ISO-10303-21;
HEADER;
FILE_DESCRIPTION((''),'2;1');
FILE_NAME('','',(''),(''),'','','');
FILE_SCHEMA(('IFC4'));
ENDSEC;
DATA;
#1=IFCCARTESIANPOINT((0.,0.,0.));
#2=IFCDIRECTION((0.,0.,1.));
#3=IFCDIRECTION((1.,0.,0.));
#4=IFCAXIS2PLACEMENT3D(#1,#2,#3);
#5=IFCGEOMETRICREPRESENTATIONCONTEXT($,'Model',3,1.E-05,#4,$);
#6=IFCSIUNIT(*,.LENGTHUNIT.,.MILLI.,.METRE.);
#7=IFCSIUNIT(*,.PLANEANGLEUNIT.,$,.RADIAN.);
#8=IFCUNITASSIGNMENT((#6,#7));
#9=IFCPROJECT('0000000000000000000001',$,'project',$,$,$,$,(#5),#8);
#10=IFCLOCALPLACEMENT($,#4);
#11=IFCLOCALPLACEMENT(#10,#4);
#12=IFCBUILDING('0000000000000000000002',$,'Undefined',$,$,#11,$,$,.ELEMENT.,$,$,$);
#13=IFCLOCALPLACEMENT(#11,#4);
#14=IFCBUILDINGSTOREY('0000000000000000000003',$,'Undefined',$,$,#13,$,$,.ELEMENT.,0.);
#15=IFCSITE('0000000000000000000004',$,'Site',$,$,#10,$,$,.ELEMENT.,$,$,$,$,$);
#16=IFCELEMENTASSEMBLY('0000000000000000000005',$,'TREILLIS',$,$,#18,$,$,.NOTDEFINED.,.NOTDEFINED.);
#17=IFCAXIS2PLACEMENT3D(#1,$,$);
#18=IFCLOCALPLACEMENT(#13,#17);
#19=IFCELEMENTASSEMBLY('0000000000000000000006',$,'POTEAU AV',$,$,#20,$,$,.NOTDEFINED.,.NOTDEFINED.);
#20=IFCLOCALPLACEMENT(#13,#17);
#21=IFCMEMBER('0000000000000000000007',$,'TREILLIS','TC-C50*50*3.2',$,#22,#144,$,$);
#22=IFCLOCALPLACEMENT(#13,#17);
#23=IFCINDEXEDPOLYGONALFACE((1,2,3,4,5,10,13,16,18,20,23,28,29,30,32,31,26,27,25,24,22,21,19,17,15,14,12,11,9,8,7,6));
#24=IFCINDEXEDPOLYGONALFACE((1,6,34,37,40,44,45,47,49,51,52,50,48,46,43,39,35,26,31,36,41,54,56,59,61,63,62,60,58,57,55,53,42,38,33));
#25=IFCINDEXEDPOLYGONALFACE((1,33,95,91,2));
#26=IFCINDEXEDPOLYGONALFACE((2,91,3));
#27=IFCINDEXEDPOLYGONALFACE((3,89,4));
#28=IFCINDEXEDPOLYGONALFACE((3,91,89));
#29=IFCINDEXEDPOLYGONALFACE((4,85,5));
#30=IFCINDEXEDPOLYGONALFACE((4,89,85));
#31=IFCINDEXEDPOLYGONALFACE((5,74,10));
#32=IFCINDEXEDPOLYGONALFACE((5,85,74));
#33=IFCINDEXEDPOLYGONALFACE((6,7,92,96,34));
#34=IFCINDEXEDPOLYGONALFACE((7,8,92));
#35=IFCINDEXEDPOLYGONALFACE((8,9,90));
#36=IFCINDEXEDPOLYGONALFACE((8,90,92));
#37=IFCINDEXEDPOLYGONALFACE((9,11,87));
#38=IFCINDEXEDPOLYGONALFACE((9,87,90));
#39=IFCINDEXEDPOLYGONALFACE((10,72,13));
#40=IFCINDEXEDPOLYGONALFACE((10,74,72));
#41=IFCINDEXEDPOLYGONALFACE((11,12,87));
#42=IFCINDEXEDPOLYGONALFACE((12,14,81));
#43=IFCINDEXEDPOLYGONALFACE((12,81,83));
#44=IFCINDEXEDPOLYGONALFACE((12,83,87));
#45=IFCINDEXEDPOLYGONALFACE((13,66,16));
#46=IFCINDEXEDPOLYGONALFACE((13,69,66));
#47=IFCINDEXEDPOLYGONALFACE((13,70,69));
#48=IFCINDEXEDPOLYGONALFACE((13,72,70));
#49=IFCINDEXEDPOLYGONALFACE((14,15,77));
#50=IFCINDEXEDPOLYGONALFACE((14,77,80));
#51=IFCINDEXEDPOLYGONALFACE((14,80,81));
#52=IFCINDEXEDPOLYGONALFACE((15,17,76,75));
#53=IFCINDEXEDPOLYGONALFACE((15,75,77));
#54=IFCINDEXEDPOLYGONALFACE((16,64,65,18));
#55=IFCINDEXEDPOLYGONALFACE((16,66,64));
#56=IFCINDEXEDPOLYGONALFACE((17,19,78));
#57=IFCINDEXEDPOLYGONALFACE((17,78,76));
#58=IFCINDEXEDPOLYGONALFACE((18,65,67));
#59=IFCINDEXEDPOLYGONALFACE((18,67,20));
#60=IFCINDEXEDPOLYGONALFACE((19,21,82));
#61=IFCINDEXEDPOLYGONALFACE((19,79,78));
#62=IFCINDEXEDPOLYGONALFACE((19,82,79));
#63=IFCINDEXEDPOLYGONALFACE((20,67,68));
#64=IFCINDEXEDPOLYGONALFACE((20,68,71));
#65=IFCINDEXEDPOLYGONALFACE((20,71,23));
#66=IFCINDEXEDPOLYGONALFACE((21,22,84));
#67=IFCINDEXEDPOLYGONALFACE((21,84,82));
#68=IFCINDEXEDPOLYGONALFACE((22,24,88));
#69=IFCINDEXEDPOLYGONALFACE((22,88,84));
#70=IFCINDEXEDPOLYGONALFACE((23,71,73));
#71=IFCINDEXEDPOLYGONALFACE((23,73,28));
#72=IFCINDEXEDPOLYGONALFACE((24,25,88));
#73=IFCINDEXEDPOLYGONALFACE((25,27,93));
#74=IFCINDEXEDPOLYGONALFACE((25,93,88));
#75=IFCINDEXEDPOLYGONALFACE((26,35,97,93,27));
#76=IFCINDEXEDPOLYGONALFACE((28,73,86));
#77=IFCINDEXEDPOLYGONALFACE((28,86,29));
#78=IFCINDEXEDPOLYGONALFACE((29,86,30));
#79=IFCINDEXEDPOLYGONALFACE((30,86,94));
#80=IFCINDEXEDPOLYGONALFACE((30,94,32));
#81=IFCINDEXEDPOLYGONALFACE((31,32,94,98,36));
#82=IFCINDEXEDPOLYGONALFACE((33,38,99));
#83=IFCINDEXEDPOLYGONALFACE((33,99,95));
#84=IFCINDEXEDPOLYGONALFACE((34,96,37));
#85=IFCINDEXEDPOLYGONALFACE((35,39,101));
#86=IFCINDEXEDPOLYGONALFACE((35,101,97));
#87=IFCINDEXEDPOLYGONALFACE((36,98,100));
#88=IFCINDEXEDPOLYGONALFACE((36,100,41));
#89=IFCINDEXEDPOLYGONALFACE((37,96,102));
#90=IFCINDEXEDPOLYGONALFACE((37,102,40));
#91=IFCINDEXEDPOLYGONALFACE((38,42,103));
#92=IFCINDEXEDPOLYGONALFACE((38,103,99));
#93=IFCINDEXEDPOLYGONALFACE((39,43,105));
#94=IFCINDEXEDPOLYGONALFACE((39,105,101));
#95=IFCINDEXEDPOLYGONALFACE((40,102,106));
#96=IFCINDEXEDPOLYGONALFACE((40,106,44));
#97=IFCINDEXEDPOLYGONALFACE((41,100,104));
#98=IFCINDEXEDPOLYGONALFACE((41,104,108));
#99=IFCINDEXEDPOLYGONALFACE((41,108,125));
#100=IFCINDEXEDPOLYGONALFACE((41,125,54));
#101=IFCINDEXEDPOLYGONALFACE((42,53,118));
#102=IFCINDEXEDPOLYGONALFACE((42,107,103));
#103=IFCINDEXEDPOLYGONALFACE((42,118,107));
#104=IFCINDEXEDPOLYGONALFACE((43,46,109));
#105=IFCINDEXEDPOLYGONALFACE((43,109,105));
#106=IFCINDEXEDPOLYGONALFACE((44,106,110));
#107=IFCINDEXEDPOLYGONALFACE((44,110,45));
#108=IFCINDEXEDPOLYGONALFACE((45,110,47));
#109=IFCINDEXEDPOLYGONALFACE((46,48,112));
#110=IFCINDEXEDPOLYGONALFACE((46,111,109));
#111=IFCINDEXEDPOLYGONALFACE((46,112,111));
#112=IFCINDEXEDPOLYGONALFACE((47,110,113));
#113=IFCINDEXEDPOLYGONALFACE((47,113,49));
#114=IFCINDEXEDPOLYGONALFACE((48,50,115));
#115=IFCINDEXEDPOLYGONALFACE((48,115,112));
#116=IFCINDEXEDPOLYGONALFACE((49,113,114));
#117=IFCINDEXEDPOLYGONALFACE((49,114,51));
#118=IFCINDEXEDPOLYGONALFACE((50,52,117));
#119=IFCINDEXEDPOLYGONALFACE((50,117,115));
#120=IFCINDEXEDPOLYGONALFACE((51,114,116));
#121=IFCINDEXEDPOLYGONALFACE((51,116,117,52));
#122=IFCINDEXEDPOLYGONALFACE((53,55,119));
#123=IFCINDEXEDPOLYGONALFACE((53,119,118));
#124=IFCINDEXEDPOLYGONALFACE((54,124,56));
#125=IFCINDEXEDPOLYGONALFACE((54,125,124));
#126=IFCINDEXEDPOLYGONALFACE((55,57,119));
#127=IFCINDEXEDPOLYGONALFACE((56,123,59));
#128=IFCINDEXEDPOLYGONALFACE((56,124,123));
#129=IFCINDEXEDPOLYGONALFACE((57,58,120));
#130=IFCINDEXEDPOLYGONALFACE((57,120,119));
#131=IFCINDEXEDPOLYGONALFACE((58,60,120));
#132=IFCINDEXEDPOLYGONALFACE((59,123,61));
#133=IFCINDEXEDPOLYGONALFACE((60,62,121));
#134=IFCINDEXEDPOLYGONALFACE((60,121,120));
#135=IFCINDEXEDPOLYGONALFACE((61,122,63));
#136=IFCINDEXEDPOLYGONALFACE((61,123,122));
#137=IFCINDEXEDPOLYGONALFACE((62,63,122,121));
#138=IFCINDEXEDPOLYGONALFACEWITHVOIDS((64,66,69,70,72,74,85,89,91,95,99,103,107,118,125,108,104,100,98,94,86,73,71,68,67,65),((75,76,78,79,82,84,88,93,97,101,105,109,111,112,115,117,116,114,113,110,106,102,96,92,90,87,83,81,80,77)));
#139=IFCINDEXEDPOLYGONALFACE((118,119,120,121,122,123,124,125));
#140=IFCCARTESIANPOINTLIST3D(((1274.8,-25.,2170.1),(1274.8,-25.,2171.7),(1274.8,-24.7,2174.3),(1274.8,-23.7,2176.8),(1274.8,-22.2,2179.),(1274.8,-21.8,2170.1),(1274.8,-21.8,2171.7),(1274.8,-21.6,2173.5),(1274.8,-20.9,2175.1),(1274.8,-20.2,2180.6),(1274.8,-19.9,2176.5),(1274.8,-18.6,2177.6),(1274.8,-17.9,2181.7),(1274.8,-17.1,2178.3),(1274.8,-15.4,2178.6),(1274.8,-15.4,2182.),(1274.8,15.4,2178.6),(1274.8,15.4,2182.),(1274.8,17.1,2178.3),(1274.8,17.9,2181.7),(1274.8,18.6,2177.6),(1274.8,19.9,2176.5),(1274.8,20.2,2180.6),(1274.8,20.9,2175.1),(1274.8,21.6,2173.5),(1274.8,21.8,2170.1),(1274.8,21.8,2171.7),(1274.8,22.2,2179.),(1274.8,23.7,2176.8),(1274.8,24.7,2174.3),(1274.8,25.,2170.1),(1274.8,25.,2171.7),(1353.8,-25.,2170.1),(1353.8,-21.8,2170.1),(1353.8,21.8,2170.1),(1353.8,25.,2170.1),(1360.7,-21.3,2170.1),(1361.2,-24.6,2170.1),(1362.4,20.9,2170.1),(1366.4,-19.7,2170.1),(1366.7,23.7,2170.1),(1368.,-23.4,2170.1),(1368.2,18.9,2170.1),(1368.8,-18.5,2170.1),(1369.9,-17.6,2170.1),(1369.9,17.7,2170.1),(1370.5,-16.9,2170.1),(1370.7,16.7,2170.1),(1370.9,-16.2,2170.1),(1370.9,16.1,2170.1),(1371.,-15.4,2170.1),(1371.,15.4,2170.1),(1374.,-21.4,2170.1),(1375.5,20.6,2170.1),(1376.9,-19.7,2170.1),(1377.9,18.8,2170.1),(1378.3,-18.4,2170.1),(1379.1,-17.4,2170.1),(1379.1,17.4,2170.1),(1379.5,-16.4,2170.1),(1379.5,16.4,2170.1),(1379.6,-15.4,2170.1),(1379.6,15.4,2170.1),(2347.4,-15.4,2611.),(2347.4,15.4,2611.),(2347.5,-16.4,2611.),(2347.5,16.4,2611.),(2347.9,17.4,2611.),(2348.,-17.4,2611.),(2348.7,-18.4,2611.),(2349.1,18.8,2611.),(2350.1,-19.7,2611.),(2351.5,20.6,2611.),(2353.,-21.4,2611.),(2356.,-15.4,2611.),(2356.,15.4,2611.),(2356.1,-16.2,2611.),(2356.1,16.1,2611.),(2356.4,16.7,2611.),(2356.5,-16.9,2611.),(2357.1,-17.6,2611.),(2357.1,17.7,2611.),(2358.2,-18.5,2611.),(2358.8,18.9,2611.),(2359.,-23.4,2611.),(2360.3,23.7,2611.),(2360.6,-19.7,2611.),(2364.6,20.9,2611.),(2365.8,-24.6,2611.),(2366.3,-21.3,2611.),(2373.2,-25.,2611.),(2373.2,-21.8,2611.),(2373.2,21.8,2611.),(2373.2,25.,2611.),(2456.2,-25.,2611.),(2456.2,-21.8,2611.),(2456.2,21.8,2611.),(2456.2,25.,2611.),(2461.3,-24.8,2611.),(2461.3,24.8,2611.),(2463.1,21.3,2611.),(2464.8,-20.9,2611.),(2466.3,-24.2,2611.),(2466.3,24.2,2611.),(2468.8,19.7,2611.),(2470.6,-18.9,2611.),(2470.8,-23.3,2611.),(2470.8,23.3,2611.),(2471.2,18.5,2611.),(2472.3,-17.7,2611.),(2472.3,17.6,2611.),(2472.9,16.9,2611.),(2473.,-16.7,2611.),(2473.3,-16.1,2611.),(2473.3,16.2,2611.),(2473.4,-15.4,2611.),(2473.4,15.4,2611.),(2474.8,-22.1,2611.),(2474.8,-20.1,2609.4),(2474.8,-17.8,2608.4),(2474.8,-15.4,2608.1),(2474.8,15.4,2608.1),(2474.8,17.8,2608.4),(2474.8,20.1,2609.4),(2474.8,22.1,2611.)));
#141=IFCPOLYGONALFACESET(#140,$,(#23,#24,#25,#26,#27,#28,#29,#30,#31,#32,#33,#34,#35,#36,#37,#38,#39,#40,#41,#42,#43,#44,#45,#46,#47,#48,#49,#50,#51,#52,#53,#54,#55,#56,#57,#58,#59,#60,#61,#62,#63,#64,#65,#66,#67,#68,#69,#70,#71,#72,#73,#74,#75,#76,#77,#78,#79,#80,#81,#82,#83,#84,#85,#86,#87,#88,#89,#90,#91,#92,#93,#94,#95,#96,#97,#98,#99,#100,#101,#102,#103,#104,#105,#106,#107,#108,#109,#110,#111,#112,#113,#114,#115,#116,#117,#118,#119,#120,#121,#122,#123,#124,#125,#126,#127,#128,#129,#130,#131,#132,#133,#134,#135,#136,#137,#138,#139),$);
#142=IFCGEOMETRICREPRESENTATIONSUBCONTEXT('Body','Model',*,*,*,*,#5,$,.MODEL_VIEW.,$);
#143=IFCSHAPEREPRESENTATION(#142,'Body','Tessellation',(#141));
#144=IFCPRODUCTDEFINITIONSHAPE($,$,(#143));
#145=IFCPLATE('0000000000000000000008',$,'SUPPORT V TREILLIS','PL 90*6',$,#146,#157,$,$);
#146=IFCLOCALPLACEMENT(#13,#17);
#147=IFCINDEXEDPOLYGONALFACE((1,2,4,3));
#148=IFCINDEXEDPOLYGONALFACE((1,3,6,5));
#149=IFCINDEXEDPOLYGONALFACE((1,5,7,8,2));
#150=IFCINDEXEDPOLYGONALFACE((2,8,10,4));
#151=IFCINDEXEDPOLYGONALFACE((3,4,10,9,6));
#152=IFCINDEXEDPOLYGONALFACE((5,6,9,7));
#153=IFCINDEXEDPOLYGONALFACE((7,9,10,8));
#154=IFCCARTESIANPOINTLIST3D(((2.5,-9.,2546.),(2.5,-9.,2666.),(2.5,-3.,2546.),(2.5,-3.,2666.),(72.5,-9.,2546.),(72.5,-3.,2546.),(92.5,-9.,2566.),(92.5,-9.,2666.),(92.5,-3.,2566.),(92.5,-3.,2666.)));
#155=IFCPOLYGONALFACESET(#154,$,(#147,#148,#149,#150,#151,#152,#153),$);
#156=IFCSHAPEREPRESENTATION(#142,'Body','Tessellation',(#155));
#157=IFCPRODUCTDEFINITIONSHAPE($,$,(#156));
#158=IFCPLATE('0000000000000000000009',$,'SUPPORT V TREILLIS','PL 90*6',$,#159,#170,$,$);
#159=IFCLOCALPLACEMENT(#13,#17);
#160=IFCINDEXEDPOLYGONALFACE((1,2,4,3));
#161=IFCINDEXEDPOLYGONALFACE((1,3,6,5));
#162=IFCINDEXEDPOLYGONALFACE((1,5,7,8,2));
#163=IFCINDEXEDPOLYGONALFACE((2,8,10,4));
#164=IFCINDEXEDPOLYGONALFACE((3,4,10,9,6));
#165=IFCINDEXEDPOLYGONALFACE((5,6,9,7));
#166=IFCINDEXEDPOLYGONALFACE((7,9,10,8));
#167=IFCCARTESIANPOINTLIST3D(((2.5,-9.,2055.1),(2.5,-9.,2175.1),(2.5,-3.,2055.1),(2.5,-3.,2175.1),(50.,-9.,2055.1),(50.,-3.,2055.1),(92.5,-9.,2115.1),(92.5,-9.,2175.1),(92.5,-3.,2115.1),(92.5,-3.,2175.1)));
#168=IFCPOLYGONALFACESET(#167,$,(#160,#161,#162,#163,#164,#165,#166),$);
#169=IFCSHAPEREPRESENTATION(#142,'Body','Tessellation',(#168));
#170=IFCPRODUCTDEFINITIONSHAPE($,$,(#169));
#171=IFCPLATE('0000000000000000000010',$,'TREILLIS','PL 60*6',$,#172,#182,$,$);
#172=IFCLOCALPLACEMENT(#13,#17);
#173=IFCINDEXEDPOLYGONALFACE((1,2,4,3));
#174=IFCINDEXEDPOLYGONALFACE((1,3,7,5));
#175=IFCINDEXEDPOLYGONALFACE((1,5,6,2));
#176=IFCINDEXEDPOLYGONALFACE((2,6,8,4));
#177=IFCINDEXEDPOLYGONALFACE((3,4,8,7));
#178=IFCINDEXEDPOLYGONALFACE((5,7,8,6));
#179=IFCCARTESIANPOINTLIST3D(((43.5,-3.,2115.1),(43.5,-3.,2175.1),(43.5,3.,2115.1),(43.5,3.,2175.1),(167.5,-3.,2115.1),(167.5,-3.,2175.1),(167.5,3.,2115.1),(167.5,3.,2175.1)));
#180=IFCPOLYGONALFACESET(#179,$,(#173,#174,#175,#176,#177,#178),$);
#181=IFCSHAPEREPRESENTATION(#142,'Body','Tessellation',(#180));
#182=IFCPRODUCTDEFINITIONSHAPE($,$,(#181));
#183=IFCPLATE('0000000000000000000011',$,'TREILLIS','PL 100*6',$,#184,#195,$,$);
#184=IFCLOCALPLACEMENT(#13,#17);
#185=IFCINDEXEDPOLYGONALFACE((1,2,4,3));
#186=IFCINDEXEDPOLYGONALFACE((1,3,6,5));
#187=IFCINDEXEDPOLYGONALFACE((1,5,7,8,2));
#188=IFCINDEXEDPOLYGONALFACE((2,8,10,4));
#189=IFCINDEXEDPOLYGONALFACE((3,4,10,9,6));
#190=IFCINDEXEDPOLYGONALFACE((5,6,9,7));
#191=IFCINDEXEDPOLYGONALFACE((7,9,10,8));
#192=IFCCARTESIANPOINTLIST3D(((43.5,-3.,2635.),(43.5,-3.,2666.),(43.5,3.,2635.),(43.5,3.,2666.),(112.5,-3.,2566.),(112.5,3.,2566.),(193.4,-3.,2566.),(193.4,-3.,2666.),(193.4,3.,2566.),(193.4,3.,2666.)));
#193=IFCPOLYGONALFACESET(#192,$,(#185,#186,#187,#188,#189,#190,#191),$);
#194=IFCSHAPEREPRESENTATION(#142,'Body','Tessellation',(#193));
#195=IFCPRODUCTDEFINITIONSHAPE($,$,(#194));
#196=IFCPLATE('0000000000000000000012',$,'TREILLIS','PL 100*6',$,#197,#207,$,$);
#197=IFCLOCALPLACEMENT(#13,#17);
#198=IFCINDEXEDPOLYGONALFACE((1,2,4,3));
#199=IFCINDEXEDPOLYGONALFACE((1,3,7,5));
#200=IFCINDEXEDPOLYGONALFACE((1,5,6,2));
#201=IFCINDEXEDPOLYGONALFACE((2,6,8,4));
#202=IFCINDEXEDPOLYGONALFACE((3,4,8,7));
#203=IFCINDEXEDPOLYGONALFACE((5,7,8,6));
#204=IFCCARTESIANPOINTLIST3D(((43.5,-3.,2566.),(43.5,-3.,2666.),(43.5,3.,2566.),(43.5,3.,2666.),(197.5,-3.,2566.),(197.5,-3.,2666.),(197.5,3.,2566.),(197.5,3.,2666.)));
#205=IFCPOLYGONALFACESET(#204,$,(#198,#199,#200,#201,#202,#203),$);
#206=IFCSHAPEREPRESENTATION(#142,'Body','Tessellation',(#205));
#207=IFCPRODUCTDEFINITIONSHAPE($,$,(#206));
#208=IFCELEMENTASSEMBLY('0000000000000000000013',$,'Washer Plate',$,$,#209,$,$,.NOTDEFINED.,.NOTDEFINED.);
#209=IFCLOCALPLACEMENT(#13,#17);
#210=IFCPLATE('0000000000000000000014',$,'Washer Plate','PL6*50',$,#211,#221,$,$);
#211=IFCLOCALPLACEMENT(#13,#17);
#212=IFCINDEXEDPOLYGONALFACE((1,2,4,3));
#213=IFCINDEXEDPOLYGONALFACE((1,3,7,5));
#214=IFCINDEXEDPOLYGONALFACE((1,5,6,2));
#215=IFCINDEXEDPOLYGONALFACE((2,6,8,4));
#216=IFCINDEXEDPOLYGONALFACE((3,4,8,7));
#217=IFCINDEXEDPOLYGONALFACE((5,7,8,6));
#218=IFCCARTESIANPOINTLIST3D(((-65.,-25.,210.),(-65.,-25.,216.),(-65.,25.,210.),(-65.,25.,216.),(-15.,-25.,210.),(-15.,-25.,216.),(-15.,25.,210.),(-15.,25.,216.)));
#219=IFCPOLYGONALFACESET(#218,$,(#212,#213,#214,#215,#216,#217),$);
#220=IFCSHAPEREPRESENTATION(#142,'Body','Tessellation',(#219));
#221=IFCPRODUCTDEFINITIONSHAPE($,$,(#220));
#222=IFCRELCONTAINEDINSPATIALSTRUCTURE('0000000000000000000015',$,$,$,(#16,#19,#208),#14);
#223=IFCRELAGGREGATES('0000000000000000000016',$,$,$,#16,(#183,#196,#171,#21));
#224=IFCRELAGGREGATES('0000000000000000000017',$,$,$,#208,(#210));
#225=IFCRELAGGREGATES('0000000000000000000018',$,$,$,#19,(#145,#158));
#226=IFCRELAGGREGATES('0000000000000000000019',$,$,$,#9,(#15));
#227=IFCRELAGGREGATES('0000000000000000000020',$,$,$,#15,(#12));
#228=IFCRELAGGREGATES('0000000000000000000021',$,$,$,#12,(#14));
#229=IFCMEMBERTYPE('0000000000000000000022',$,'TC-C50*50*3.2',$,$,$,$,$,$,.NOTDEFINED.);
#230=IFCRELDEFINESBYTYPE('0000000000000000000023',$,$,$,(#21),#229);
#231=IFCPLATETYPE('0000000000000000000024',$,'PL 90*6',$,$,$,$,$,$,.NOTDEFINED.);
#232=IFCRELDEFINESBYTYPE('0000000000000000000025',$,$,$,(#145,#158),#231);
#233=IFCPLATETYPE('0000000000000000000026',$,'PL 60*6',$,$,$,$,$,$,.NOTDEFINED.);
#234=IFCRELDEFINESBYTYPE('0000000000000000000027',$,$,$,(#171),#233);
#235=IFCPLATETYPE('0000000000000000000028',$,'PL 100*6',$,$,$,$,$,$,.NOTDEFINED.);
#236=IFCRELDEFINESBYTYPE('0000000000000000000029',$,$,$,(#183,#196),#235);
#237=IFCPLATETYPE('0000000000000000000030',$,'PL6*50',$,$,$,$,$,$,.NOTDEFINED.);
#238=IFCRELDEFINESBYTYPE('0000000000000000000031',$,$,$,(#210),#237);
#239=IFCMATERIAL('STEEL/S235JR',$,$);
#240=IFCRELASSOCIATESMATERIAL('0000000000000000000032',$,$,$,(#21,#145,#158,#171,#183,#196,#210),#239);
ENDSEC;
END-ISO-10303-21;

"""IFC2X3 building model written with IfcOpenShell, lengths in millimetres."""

from ifc_helpers import new_model, si_unit, frame, origin_with_axes, origin_2d_with_axis, place, context, subcontext, project, spatial, polyline, hollow_rectangle, outline, extrude, clip, halfspace, material, type_object, element, aggregate, save


model = new_model("IFC2X3")

# Units and contexts
model_context = context("Model", 3, precision=1e-05, world=origin_with_axes())
body_context = subcontext(model_context, "Body", "Model", "MODEL_VIEW")
ifc_project = project(units=[si_unit("LENGTHUNIT", "METRE", prefix="MILLI"), si_unit("PLANEANGLEUNIT", "RADIAN")], contexts=[model_context])

# Site, building, storey
site_placement = place(None, origin_with_axes())
site = spatial("IfcSite", under=ifc_project, at=site_placement, Name="Site", CompositionType="ELEMENT")
building_placement = place(site_placement, origin_with_axes())
building = spatial("IfcBuilding", under=site, at=building_placement, Name="Undefined", CompositionType="ELEMENT")
storey_placement = place(building_placement, origin_with_axes())
storey = spatial("IfcBuildingStorey", under=building, at=storey_placement, Name="Undefined", CompositionType="ELEMENT", Elevation=0.0)

# Shared definitions
ifc_material_1 = material(Name="STEEL/S235JR")

# Element assembly
assembly_1_placement = place(storey_placement, origin_with_axes())
assembly_1 = element("IfcElementAssembly", 1, at=assembly_1_placement, inside=storey, Name="TREILLIS", AssemblyPlace="NOTDEFINED", PredefinedType="NOTDEFINED")

# Element assembly
assembly_2_placement = place(storey_placement, origin_with_axes())
assembly_2 = element("IfcElementAssembly", 2, at=assembly_2_placement, inside=storey, Name="POTEAU AV", AssemblyPlace="NOTDEFINED", PredefinedType="NOTDEFINED")

# Member
member_type = type_object("IfcMemberType", Name="TC-C50*50*3.2", PredefinedType="NOTDEFINED")
member_1_placement = place(assembly_1_placement, frame((1249.9, 0.0, 2145.1), z_axis=(-0.371369, 0.0, 0.928485), x_axis=(0.928485, 0.0, 0.371369)))
member_1 = element("IfcMember", 3, at=member_1_placement, type_object=member_type, material=ifc_material_1, Name="TREILLIS", Description="TC-C50*50*3.2", context=body_context, shape_type="Clipping", body=[
    clip(clip(clip(clip(extrude(hollow_rectangle(XDim=50.0, YDim=50.0, WallThickness=3.2, InnerFilletRadius=6.4, OuterFilletRadius=9.6, at=origin_2d_with_axis()), frame((1346.2, 0.0, 0.0), z_axis=(-1.0, 0.0, 0.0), x_axis=(0.0, -1.0, 0.0)), (0.0, 0.0, 1.0), 1346.2), halfspace(frame((1309.2, -25.0, -25.0), z_axis=(0.928485, 0.0, -0.371369), x_axis=(0.371369, 0.0, 0.928485)), False)), halfspace(frame((16.8, 25.0, -25.0), z_axis=(-0.928538, 0.0, 0.371238), x_axis=(0.371238, 0.0, 0.928538)), False)), halfspace(frame((1192.3, 25.0, 24.9), z_axis=(0.371369, 0.0, 0.928485), x_axis=(0.928485, 0.0, -0.371369)), False)), halfspace(frame((129.8, 25.0, -25.1), z_axis=(-0.371369, 0.0, -0.928485), x_axis=(-0.928485, 0.0, 0.371369)), False)),
])

# Plates
plate_type_1 = type_object("IfcPlateType", Name="PL 90*6", PredefinedType="NOTDEFINED")
plate_1_placement = place(assembly_2_placement, frame((47.5, -6.0, 2666.0), z_axis=(0.0, -1.0, 0.0), x_axis=(0.0, 0.0, -1.0)))
plate_1 = element("IfcPlate", 4, at=plate_1_placement, type_object=plate_type_1, material=ifc_material_1, Name="SUPPORT V TREILLIS", Description="PL 90*6", context=body_context, shape_type="Clipping", body=[
    clip(extrude(outline(polyline([(120.0, -45.0), (0.0, -45.0), (0.0, 45.0), (100.0, 45.0), (120.0, 25.0), (120.0, -45.0)])), frame((0.0, 0.0, -3.0), z_axis=(0.0, 0.0, 1.0), x_axis=(1.0, 0.0, 0.0)), (0.0, 0.0, 1.0), 6.0), halfspace(frame((190.0, -45.0, -3.0), z_axis=(0.707107, 0.707107, 0.0), x_axis=(0.0, 0.0, 1.0)), False)),
])
plate_2_placement = place(assembly_2_placement, frame((47.5, -6.0, 2175.1), z_axis=(0.0, -1.0, 0.0), x_axis=(0.0, 0.0, -1.0)))
plate_2 = element("IfcPlate", 5, at=plate_2_placement, type_object=plate_type_1, material=ifc_material_1, Name="SUPPORT V TREILLIS", Description="PL 90*6", context=body_context, shape_type="Clipping", body=[
    clip(extrude(outline(polyline([(120.0, -45.0), (0.0, -45.0), (0.0, 45.0), (60.0, 45.0), (120.0, 2.5), (120.0, -45.0)])), frame((0.0, 0.0, -3.0), z_axis=(0.0, 0.0, 1.0), x_axis=(1.0, 0.0, 0.0)), (0.0, 0.0, 1.0), 6.0), halfspace(frame((187.1, -45.0, 3.0), z_axis=(0.578017, 0.816024, 0.0), x_axis=(-0.816024, 0.578017, 0.0)), False)),
])
plate_type_2 = type_object("IfcPlateType", Name="PL 60*6", PredefinedType="NOTDEFINED")
plate_3_placement = place(assembly_1_placement, frame((43.5, 0.0, 2145.1), z_axis=(0.0, -1.0, 0.0), x_axis=(1.0, 0.0, 0.0)))
plate_3 = element("IfcPlate", 6, at=plate_3_placement, type_object=plate_type_2, material=ifc_material_1, Name="TREILLIS", Description="PL 60*6", context=body_context, shape_type="SweptSolid", body=[
    extrude(outline(polyline([(0.0, -30.0), (0.0, 30.0), (124.0, 30.0), (124.0, -30.0), (0.0, -30.0)])), frame((0.0, 0.0, -3.0), z_axis=(0.0, 0.0, 1.0), x_axis=(1.0, 0.0, 0.0)), (0.0, 0.0, 1.0), 6.0),
])
plate_type_3 = type_object("IfcPlateType", Name="PL 100*6", PredefinedType="NOTDEFINED")
plate_4_placement = place(assembly_1_placement, frame((43.5, 0.0, 2616.0), z_axis=(0.0, -1.0, 0.0), x_axis=(1.0, 0.0, 0.0)))
plate_4 = element("IfcPlate", 7, at=plate_4_placement, type_object=plate_type_3, material=ifc_material_1, Name="TREILLIS", Description="PL 100*6", context=body_context, shape_type="Clipping", body=[
    clip(extrude(outline(polyline([(0.0, 19.0), (0.0, 50.0), (149.9, 50.0), (149.9, -50.0), (69.0, -50.0), (0.0, 19.0)])), frame((0.0, 0.0, -3.0), z_axis=(0.0, 0.0, 1.0), x_axis=(1.0, 0.0, 0.0)), (0.0, 0.0, 1.0), 6.0), halfspace(frame((69.0, -50.0, 3.0), z_axis=(-0.707107, -0.707107, 0.0), x_axis=(0.0, 0.0, -1.0)), False)),
])
plate_5_placement = place(assembly_1_placement, frame((43.5, 0.0, 2616.0), z_axis=(0.0, -1.0, 0.0), x_axis=(1.0, 0.0, 0.0)))
plate_5 = element("IfcPlate", 8, at=plate_5_placement, type_object=plate_type_3, material=ifc_material_1, Name="TREILLIS", Description="PL 100*6", context=body_context, shape_type="SweptSolid", body=[
    extrude(outline(polyline([(0.0, -50.0), (0.0, 50.0), (154.0, 50.0), (154.0, -50.0), (0.0, -50.0)])), frame((0.0, 0.0, -3.0), z_axis=(0.0, 0.0, 1.0), x_axis=(1.0, 0.0, 0.0)), (0.0, 0.0, 1.0), 6.0),
])

# Element assembly, plate
assembly_3_placement = place(storey_placement, origin_with_axes())
assembly_3 = element("IfcElementAssembly", 9, at=assembly_3_placement, inside=storey, Name="Washer Plate", AssemblyPlace="NOTDEFINED", PredefinedType="NOTDEFINED")
plate_type_4 = type_object("IfcPlateType", Name="PL6*50", PredefinedType="NOTDEFINED")
plate_6_placement = place(assembly_3_placement, frame((-15.0, 25.0, 213.0), z_axis=(0.0, 0.0, -1.0), x_axis=(0.0, -1.0, 0.0)))
plate_6 = element("IfcPlate", 10, at=plate_6_placement, type_object=plate_type_4, material=ifc_material_1, Name="Washer Plate", Description="PL6*50", context=body_context, shape_type="SweptSolid", body=[
    extrude(outline(polyline([(0.0, 0.0), (50.0, 0.0), (50.0, 50.0), (0.0, 50.0), (0.0, 0.0)])), frame((0.0, 0.0, -3.0), z_axis=(0.0, 0.0, 1.0), x_axis=(1.0, 0.0, 0.0)), (0.0, 0.0, 1.0), 6.0),
])

aggregate(assembly_1, [plate_4, plate_5, plate_3, member_1])

aggregate(assembly_3, [plate_6])
aggregate(assembly_2, [plate_1, plate_2])

save(model, "model.ifc")
